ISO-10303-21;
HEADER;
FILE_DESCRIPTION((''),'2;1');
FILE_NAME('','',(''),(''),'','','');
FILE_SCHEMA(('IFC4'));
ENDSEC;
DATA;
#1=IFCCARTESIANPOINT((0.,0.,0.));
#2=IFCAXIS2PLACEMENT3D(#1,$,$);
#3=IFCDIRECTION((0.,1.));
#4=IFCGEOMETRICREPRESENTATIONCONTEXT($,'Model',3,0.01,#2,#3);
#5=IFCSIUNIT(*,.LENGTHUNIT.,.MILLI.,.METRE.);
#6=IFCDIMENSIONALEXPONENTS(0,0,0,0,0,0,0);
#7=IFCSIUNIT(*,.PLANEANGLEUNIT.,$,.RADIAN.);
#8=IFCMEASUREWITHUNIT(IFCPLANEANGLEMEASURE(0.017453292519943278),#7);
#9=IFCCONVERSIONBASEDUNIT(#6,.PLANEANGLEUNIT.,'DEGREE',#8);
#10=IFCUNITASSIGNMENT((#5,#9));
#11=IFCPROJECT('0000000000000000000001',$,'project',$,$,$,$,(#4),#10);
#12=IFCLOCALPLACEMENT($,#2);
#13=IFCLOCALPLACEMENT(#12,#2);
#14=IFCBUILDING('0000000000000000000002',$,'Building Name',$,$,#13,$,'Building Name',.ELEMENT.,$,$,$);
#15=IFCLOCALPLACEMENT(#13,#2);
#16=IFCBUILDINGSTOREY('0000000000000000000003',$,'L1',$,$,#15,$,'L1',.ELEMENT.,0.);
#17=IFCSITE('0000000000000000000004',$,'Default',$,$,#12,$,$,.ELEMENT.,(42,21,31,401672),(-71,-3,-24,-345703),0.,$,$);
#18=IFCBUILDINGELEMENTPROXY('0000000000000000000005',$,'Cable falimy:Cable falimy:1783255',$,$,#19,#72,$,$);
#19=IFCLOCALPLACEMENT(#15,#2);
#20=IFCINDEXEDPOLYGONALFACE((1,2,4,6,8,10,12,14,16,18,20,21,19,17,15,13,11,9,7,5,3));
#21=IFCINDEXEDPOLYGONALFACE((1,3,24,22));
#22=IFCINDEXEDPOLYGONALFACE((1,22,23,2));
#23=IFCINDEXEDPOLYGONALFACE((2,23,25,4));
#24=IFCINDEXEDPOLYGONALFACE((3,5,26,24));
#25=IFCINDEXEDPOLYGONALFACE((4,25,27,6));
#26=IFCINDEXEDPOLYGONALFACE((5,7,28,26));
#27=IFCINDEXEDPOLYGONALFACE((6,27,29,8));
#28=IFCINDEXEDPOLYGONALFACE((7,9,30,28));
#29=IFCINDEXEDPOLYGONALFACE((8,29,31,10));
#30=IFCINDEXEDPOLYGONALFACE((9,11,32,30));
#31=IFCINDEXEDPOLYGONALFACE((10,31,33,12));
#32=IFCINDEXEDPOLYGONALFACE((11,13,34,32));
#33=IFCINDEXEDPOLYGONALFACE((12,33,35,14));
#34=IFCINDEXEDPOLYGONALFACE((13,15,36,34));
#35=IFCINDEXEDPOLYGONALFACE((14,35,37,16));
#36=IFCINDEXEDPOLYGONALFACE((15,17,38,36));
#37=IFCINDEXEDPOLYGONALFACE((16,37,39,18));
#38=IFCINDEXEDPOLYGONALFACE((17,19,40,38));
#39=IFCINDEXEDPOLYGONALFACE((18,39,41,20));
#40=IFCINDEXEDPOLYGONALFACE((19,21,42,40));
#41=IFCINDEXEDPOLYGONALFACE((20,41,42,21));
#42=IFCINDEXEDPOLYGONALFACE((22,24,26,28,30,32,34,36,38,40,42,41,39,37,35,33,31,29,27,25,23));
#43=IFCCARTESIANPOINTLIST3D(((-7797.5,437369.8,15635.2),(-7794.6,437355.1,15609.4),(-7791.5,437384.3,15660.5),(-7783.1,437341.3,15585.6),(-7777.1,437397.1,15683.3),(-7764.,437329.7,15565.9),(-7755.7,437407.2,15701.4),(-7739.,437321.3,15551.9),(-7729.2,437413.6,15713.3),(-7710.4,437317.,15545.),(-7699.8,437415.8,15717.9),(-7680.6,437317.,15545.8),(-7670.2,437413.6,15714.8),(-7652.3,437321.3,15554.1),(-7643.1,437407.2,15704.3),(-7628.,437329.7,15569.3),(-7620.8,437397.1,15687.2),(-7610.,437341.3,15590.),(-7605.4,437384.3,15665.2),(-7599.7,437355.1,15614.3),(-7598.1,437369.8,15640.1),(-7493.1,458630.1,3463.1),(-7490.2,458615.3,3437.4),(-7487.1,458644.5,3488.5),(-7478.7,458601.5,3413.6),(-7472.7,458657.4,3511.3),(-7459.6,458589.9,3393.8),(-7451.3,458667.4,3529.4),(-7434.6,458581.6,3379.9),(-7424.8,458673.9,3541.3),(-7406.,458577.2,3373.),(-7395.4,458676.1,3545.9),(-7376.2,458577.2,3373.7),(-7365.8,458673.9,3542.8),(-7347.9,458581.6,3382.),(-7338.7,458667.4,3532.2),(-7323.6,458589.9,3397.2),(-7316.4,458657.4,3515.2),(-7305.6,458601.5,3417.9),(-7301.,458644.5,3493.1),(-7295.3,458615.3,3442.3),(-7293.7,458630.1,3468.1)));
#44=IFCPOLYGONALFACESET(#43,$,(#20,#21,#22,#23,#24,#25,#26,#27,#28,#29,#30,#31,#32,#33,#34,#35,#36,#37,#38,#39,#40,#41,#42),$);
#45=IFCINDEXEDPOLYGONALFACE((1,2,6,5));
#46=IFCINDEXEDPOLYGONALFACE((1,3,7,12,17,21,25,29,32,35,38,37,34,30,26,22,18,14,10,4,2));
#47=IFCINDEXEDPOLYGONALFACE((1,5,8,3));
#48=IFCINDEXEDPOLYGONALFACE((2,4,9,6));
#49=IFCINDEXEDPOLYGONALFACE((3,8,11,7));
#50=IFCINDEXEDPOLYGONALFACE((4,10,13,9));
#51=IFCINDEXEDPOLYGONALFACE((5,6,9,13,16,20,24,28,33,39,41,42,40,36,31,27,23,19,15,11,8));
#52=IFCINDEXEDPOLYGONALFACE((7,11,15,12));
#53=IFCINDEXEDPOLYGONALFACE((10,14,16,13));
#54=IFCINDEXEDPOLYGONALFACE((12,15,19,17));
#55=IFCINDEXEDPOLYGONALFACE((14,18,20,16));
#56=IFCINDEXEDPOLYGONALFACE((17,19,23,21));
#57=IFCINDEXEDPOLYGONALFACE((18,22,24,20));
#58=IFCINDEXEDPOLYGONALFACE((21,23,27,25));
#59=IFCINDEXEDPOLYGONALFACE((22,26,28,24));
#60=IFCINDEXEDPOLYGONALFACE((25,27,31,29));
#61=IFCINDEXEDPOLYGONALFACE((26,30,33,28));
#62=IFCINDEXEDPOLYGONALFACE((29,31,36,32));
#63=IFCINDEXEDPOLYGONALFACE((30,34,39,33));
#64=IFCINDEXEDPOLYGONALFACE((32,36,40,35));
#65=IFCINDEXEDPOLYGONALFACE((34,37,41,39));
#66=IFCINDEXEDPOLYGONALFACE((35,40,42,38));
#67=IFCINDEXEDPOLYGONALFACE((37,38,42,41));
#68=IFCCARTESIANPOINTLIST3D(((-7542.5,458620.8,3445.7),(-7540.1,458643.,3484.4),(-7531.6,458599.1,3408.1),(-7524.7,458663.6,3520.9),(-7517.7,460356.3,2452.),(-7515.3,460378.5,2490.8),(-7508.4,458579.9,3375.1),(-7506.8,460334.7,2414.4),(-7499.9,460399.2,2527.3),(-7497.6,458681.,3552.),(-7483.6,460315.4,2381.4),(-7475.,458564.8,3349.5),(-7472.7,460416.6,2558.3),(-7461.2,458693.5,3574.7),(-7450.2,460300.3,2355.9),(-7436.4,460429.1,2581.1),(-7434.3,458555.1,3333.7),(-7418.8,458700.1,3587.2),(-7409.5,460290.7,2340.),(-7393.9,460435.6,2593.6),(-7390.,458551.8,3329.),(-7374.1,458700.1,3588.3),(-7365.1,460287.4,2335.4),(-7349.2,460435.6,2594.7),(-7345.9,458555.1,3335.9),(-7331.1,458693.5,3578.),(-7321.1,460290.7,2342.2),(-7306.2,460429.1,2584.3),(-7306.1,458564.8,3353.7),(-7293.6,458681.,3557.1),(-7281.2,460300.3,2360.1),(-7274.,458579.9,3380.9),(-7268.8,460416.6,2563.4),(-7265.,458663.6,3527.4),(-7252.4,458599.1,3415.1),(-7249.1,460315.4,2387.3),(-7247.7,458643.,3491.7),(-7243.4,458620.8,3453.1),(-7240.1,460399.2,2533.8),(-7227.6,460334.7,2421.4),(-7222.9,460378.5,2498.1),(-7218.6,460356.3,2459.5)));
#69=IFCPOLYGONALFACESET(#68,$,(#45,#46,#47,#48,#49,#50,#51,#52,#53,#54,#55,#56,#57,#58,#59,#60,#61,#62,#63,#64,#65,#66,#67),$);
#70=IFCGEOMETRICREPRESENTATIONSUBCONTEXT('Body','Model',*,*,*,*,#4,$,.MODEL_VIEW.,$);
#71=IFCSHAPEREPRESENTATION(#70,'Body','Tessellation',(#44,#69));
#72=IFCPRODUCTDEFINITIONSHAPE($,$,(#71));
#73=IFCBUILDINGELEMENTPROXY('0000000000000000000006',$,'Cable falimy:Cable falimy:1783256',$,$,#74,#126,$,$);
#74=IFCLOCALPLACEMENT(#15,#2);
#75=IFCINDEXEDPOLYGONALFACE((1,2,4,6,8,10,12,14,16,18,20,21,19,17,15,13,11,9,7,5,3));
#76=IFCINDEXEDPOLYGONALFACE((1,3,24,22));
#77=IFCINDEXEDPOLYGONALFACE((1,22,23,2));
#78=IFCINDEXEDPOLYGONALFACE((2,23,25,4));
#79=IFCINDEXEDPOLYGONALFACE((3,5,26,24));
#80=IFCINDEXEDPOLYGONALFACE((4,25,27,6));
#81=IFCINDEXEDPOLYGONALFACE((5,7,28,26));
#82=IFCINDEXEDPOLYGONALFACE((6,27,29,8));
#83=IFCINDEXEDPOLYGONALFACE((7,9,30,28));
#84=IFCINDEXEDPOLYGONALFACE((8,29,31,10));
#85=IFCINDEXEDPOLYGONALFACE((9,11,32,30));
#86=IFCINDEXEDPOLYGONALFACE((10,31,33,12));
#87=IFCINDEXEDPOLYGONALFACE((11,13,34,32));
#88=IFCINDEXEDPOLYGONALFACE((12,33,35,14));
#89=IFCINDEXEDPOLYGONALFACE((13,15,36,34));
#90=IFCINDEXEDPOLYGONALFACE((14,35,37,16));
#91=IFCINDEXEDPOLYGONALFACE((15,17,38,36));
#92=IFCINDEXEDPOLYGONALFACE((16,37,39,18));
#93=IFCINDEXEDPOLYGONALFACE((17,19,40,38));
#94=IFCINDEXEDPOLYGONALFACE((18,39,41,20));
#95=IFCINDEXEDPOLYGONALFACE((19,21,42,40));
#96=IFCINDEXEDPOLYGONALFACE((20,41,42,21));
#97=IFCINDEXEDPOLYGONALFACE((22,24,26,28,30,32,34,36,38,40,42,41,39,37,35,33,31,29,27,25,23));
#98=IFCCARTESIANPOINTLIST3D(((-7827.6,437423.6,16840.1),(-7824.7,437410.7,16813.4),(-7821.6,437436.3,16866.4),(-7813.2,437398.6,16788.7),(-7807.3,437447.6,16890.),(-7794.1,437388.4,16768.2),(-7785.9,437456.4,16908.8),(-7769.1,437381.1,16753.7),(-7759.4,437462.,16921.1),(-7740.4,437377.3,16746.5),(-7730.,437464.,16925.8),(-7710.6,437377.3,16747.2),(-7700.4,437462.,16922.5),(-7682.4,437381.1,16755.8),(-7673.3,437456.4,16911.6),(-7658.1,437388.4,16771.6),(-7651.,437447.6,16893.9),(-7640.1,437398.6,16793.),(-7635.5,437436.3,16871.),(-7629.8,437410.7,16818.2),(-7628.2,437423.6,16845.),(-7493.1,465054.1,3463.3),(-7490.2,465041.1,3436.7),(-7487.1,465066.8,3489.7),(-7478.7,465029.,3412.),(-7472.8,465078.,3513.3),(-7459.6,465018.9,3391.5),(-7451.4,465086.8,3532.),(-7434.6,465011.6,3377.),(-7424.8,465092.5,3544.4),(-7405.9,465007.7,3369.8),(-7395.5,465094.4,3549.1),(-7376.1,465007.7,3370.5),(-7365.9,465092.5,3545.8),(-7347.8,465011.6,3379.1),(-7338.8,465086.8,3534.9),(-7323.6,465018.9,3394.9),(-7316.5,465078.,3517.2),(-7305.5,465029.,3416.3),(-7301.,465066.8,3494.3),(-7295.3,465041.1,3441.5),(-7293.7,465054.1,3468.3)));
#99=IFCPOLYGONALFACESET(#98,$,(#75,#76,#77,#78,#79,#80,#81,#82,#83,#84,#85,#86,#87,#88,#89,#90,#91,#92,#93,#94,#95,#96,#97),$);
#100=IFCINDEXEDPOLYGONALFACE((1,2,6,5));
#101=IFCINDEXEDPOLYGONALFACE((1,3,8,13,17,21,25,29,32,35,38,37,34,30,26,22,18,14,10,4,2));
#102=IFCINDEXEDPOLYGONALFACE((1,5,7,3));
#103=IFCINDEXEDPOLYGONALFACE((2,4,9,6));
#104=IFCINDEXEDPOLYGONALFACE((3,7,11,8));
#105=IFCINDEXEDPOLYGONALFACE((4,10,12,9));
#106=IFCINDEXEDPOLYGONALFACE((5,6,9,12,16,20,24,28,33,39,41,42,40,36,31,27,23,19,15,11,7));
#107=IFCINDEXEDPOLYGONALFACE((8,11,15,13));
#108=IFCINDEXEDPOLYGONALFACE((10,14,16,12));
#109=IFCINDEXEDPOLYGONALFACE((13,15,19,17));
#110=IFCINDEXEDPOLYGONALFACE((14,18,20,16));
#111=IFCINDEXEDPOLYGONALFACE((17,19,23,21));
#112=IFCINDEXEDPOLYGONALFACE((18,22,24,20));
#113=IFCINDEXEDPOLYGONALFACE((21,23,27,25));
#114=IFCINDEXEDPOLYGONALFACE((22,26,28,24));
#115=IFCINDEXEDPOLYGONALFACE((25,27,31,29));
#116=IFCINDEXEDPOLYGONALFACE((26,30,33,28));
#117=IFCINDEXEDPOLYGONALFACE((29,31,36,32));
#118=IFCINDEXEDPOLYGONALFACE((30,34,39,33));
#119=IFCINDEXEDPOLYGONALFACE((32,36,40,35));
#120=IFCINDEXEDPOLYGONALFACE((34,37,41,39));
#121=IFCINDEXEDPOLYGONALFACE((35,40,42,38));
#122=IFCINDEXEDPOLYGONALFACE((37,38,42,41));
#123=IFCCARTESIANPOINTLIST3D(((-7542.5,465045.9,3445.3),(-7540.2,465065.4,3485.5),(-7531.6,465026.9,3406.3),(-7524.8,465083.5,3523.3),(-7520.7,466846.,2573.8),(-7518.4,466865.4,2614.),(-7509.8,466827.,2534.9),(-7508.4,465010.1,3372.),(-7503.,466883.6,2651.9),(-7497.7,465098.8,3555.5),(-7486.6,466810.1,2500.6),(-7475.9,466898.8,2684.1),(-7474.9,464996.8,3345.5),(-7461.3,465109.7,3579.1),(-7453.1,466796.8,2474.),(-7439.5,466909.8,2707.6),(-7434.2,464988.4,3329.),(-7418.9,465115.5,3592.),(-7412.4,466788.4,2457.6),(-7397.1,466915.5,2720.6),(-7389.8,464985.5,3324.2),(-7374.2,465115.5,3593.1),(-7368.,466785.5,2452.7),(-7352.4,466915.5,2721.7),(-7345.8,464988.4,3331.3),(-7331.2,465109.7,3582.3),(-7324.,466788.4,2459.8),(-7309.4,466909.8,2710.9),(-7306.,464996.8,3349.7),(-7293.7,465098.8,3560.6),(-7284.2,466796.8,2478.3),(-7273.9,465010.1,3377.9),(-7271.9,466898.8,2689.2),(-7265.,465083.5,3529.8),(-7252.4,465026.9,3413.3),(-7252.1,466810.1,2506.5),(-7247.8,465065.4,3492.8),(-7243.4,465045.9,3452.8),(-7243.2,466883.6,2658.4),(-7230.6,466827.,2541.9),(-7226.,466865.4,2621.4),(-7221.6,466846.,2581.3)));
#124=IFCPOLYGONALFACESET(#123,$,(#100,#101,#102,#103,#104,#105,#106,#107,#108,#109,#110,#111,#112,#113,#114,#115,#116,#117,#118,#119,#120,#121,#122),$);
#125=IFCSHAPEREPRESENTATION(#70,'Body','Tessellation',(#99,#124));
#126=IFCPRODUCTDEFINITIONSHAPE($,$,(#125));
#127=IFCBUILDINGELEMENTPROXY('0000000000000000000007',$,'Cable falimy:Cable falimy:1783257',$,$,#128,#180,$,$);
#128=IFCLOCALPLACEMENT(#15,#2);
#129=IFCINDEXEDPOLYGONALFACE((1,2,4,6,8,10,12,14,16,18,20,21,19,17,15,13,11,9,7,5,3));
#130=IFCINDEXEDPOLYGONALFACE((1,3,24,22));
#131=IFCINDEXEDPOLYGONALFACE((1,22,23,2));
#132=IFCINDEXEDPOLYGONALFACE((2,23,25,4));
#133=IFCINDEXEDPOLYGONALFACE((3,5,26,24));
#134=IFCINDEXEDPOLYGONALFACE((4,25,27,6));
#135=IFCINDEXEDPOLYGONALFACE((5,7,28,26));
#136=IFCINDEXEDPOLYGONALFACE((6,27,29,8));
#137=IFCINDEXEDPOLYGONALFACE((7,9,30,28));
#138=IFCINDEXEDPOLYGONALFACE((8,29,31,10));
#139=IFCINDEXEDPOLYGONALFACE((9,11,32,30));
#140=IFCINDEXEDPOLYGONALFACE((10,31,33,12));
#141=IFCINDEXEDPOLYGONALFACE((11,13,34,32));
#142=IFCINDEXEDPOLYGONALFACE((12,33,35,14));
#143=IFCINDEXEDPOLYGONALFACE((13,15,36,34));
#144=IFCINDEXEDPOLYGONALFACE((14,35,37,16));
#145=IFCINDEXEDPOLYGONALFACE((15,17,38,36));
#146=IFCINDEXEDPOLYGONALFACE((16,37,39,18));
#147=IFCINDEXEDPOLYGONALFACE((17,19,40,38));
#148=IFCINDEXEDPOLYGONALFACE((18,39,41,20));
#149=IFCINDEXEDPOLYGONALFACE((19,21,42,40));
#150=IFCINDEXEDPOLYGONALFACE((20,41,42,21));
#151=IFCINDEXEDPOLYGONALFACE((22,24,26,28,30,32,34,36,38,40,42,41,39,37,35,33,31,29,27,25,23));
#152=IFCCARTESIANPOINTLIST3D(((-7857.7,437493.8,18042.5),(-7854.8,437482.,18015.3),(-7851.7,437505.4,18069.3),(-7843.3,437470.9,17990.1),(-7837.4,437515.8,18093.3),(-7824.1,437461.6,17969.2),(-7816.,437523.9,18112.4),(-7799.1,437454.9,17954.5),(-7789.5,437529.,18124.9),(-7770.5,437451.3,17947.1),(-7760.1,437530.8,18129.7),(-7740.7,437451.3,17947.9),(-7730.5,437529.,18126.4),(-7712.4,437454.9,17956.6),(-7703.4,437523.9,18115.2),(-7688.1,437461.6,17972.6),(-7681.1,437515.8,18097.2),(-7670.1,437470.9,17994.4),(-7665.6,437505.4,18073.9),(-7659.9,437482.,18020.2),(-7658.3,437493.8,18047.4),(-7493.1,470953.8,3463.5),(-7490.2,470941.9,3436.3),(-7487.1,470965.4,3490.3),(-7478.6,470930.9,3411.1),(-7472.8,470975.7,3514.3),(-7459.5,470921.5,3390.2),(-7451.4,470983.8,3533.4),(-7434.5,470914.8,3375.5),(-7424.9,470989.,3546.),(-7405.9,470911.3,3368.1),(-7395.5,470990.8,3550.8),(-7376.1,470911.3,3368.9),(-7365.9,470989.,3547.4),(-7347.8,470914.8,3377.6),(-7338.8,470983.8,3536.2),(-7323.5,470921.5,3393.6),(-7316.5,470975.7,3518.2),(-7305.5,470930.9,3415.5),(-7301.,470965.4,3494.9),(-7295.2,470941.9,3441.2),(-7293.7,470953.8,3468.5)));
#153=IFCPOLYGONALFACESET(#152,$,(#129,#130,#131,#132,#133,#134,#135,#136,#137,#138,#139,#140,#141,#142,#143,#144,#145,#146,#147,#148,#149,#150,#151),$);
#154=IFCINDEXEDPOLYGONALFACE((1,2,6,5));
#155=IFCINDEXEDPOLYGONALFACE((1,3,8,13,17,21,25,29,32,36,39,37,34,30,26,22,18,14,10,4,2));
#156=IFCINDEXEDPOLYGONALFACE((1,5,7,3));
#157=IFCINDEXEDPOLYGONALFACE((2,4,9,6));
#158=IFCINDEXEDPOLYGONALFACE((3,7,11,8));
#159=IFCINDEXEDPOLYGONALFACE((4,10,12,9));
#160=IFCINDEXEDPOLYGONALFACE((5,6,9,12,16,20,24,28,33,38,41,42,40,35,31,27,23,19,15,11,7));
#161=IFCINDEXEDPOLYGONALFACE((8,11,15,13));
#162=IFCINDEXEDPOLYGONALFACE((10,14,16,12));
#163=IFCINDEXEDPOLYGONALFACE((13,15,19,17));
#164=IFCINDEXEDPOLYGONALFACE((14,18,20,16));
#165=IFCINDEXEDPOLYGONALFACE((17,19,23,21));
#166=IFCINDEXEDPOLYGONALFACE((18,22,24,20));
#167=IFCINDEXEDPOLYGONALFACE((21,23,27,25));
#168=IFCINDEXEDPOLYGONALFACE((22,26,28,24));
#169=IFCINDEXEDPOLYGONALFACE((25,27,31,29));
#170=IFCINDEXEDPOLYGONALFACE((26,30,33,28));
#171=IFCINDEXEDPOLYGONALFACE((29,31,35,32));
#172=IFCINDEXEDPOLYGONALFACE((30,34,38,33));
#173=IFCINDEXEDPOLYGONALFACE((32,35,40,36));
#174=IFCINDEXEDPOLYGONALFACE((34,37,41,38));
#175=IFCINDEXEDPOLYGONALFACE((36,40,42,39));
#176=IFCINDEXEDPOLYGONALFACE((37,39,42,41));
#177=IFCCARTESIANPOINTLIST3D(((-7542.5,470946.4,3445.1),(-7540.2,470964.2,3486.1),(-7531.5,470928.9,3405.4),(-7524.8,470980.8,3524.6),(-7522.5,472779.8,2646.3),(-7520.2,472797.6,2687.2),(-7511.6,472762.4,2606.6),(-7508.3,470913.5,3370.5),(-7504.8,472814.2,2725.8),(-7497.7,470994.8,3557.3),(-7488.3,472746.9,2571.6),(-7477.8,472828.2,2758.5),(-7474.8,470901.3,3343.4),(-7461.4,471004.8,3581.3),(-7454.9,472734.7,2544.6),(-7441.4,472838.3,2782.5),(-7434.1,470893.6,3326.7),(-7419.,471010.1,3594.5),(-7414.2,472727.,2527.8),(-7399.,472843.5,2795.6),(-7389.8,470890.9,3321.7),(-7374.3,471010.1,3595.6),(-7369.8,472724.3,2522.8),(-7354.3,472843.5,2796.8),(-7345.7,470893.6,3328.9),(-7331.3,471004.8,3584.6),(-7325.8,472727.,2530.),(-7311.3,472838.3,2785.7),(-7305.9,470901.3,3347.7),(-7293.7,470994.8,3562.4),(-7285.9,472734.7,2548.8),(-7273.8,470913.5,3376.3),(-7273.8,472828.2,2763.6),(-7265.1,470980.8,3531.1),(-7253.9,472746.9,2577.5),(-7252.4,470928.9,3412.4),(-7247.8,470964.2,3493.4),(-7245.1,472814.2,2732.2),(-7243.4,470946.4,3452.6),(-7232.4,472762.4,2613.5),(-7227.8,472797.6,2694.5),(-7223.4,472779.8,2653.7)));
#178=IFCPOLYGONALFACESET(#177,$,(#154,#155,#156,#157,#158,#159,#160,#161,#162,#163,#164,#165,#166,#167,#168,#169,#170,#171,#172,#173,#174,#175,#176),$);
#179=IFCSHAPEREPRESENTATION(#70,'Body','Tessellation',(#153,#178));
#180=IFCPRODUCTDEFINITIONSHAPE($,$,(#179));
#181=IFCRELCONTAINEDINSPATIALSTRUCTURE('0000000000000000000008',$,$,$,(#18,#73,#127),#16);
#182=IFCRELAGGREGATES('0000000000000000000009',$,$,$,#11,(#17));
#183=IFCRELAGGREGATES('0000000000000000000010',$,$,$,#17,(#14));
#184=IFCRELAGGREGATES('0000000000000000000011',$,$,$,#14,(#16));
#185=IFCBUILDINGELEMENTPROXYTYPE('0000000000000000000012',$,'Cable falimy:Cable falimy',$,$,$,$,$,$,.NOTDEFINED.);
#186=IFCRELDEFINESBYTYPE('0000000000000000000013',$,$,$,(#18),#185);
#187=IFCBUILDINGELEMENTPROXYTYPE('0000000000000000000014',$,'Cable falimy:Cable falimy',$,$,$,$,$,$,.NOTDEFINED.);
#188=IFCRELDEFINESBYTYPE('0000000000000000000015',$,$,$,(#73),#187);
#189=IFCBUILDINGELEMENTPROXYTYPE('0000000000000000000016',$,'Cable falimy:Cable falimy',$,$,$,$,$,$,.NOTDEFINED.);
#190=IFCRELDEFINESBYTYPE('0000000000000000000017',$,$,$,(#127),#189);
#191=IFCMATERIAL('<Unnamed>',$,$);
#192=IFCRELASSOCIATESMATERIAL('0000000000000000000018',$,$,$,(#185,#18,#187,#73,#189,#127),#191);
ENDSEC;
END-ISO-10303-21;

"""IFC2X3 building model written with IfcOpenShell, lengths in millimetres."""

from ifc_helpers import new_model, entity, si_unit, converted_unit, direction, frame, frame_2d, origin, place, context, subcontext, project, spatial, circle, extrude, source, transform, mapped, material, type_object, type_shapes, element, save


model = new_model("IFC2X3")

# Units and contexts
model_context = context("Model", 3, precision=0.01, world=origin(), true_north=direction((0.0, 1.0)))
body_context = subcontext(model_context, "Body", "Model", "MODEL_VIEW")
ifc_project = project(units=[si_unit("LENGTHUNIT", "METRE", prefix="MILLI"), converted_unit("PLANEANGLEUNIT", "DEGREE", entity("IfcPlaneAngleMeasure", 0.017453292519943278), si_unit("PLANEANGLEUNIT", "RADIAN"), dimensions=[0, 0, 0, 0, 0, 0, 0])], contexts=[model_context])

# Site, building, storey
site_placement = place(None, origin())
site = spatial("IfcSite", under=ifc_project, at=site_placement, Name="Default", CompositionType="ELEMENT", RefLatitude=(42, 21, 31, 401672), RefLongitude=(-71, -3, -24, -345703), RefElevation=0.0)
building_placement = place(site_placement, origin())
building = spatial("IfcBuilding", under=site, at=building_placement, Name="Building Name", LongName="Building Name", CompositionType="ELEMENT")
storey_placement = place(building_placement, origin())
storey = spatial("IfcBuildingStorey", under=building, at=storey_placement, Name="L1", LongName="L1", CompositionType="ELEMENT", Elevation=0.0)

# Shared definitions
ifc_material = material(Name="<Unnamed>")

# Building element proxies
building_element_proxy_type_1 = type_object("IfcBuildingElementProxyType", Name="Cable falimy:Cable falimy", PredefinedType="NOTDEFINED", material=ifc_material)
shared_shape_1 = source(origin(), body_context, "Body", "SweptSolid", [
    extrude(circle(Radius=100.0, at=frame_2d((0.0, 0.0), x_axis=(1.0, 0.0))), frame((0.0, 0.0, 0.0), z_axis=(0.867765, 0.0, 0.496974), x_axis=(-0.496974, 0.0, 0.867765)), (0.0, 0.0, 1.0), 24500.0),
    extrude(circle(Radius=150.0, at=frame_2d((0.0, 0.0), x_axis=(1.0, 0.0))), frame((-1735.5, 0.0, -993.9), z_axis=(0.867765, 0.0, 0.496974), x_axis=(0.496974, 0.0, -0.867765)), (0.0, 0.0, 1.0), 2000.0),
])
type_shapes(building_element_proxy_type_1, [shared_shape_1])
proxy_1_placement = place(storey_placement, frame((-7393.2, 458626.4, 3459.1), z_axis=(-0.025001, 0.0, 0.999687), x_axis=(0.0, -1.0, 0.0)))
element("IfcBuildingElementProxy", 1, at=proxy_1_placement, inside=storey, type_object=building_element_proxy_type_1, material=ifc_material, Name="Cable falimy:Cable falimy:1783255", context=body_context, shape_type="MappedRepresentation", body=[
    mapped(shared_shape_1, transform((0.0, 0.0, 0.0), scale=1.0)),
])
building_element_proxy_type_2 = type_object("IfcBuildingElementProxyType", Name="Cable falimy:Cable falimy", PredefinedType="NOTDEFINED", material=ifc_material)
shared_shape_2 = source(origin(), body_context, "Body", "SweptSolid", [
    extrude(circle(Radius=100.0, at=frame_2d((0.0, 0.0), x_axis=(1.0, 0.0))), frame((0.0, 0.0, 0.0), z_axis=(0.900015, 0.0, 0.43586), x_axis=(-0.43586, 0.0, 0.900015)), (0.0, 0.0, 1.0), 30700.0),
    extrude(circle(Radius=150.0, at=frame_2d((0.0, 0.0), x_axis=(1.0, 0.0))), frame((-1800.0, 0.0, -871.7), z_axis=(0.900015, 0.0, 0.43586), x_axis=(0.43586, 0.0, -0.900015)), (0.0, 0.0, 1.0), 2000.0),
])
type_shapes(building_element_proxy_type_2, [shared_shape_2])
proxy_2_placement = place(storey_placement, frame((-7393.2, 465050.8, 3459.1), z_axis=(-0.025001, 0.0, 0.999687), x_axis=(0.0, -1.0, 0.0)))
element("IfcBuildingElementProxy", 2, at=proxy_2_placement, inside=storey, type_object=building_element_proxy_type_2, material=ifc_material, Name="Cable falimy:Cable falimy:1783256", context=body_context, shape_type="MappedRepresentation", body=[
    mapped(shared_shape_2, transform((0.0, 0.0, 0.0), scale=1.0)),
])
building_element_proxy_type_3 = type_object("IfcBuildingElementProxyType", Name="Cable falimy:Cable falimy", PredefinedType="NOTDEFINED", material=ifc_material)
shared_shape_3 = source(origin(), body_context, "Body", "SweptSolid", [
    extrude(circle(Radius=100.0, at=frame_2d((0.0, 0.0), x_axis=(1.0, 0.0))), frame((0.0, 0.0, 0.0), z_axis=(0.916712, 0.0, 0.399549), x_axis=(-0.399549, 0.0, 0.916712)), (0.0, 0.0, 1.0), 36500.0),
    extrude(circle(Radius=150.0, at=frame_2d((0.0, 0.0), x_axis=(1.0, 0.0))), frame((-1833.4, 0.0, -799.1), z_axis=(0.916712, 0.0, 0.399549), x_axis=(0.399549, 0.0, -0.916712)), (0.0, 0.0, 1.0), 2000.0),
])
type_shapes(building_element_proxy_type_3, [shared_shape_3])
proxy_3_placement = place(storey_placement, frame((-7393.2, 470950.8, 3459.1), z_axis=(-0.025001, 0.0, 0.999687), x_axis=(0.0, -1.0, 0.0)))
element("IfcBuildingElementProxy", 3, at=proxy_3_placement, inside=storey, type_object=building_element_proxy_type_3, material=ifc_material, Name="Cable falimy:Cable falimy:1783257", context=body_context, shape_type="MappedRepresentation", body=[
    mapped(shared_shape_3, transform((0.0, 0.0, 0.0), scale=1.0)),
])

save(model, "model.ifc")
